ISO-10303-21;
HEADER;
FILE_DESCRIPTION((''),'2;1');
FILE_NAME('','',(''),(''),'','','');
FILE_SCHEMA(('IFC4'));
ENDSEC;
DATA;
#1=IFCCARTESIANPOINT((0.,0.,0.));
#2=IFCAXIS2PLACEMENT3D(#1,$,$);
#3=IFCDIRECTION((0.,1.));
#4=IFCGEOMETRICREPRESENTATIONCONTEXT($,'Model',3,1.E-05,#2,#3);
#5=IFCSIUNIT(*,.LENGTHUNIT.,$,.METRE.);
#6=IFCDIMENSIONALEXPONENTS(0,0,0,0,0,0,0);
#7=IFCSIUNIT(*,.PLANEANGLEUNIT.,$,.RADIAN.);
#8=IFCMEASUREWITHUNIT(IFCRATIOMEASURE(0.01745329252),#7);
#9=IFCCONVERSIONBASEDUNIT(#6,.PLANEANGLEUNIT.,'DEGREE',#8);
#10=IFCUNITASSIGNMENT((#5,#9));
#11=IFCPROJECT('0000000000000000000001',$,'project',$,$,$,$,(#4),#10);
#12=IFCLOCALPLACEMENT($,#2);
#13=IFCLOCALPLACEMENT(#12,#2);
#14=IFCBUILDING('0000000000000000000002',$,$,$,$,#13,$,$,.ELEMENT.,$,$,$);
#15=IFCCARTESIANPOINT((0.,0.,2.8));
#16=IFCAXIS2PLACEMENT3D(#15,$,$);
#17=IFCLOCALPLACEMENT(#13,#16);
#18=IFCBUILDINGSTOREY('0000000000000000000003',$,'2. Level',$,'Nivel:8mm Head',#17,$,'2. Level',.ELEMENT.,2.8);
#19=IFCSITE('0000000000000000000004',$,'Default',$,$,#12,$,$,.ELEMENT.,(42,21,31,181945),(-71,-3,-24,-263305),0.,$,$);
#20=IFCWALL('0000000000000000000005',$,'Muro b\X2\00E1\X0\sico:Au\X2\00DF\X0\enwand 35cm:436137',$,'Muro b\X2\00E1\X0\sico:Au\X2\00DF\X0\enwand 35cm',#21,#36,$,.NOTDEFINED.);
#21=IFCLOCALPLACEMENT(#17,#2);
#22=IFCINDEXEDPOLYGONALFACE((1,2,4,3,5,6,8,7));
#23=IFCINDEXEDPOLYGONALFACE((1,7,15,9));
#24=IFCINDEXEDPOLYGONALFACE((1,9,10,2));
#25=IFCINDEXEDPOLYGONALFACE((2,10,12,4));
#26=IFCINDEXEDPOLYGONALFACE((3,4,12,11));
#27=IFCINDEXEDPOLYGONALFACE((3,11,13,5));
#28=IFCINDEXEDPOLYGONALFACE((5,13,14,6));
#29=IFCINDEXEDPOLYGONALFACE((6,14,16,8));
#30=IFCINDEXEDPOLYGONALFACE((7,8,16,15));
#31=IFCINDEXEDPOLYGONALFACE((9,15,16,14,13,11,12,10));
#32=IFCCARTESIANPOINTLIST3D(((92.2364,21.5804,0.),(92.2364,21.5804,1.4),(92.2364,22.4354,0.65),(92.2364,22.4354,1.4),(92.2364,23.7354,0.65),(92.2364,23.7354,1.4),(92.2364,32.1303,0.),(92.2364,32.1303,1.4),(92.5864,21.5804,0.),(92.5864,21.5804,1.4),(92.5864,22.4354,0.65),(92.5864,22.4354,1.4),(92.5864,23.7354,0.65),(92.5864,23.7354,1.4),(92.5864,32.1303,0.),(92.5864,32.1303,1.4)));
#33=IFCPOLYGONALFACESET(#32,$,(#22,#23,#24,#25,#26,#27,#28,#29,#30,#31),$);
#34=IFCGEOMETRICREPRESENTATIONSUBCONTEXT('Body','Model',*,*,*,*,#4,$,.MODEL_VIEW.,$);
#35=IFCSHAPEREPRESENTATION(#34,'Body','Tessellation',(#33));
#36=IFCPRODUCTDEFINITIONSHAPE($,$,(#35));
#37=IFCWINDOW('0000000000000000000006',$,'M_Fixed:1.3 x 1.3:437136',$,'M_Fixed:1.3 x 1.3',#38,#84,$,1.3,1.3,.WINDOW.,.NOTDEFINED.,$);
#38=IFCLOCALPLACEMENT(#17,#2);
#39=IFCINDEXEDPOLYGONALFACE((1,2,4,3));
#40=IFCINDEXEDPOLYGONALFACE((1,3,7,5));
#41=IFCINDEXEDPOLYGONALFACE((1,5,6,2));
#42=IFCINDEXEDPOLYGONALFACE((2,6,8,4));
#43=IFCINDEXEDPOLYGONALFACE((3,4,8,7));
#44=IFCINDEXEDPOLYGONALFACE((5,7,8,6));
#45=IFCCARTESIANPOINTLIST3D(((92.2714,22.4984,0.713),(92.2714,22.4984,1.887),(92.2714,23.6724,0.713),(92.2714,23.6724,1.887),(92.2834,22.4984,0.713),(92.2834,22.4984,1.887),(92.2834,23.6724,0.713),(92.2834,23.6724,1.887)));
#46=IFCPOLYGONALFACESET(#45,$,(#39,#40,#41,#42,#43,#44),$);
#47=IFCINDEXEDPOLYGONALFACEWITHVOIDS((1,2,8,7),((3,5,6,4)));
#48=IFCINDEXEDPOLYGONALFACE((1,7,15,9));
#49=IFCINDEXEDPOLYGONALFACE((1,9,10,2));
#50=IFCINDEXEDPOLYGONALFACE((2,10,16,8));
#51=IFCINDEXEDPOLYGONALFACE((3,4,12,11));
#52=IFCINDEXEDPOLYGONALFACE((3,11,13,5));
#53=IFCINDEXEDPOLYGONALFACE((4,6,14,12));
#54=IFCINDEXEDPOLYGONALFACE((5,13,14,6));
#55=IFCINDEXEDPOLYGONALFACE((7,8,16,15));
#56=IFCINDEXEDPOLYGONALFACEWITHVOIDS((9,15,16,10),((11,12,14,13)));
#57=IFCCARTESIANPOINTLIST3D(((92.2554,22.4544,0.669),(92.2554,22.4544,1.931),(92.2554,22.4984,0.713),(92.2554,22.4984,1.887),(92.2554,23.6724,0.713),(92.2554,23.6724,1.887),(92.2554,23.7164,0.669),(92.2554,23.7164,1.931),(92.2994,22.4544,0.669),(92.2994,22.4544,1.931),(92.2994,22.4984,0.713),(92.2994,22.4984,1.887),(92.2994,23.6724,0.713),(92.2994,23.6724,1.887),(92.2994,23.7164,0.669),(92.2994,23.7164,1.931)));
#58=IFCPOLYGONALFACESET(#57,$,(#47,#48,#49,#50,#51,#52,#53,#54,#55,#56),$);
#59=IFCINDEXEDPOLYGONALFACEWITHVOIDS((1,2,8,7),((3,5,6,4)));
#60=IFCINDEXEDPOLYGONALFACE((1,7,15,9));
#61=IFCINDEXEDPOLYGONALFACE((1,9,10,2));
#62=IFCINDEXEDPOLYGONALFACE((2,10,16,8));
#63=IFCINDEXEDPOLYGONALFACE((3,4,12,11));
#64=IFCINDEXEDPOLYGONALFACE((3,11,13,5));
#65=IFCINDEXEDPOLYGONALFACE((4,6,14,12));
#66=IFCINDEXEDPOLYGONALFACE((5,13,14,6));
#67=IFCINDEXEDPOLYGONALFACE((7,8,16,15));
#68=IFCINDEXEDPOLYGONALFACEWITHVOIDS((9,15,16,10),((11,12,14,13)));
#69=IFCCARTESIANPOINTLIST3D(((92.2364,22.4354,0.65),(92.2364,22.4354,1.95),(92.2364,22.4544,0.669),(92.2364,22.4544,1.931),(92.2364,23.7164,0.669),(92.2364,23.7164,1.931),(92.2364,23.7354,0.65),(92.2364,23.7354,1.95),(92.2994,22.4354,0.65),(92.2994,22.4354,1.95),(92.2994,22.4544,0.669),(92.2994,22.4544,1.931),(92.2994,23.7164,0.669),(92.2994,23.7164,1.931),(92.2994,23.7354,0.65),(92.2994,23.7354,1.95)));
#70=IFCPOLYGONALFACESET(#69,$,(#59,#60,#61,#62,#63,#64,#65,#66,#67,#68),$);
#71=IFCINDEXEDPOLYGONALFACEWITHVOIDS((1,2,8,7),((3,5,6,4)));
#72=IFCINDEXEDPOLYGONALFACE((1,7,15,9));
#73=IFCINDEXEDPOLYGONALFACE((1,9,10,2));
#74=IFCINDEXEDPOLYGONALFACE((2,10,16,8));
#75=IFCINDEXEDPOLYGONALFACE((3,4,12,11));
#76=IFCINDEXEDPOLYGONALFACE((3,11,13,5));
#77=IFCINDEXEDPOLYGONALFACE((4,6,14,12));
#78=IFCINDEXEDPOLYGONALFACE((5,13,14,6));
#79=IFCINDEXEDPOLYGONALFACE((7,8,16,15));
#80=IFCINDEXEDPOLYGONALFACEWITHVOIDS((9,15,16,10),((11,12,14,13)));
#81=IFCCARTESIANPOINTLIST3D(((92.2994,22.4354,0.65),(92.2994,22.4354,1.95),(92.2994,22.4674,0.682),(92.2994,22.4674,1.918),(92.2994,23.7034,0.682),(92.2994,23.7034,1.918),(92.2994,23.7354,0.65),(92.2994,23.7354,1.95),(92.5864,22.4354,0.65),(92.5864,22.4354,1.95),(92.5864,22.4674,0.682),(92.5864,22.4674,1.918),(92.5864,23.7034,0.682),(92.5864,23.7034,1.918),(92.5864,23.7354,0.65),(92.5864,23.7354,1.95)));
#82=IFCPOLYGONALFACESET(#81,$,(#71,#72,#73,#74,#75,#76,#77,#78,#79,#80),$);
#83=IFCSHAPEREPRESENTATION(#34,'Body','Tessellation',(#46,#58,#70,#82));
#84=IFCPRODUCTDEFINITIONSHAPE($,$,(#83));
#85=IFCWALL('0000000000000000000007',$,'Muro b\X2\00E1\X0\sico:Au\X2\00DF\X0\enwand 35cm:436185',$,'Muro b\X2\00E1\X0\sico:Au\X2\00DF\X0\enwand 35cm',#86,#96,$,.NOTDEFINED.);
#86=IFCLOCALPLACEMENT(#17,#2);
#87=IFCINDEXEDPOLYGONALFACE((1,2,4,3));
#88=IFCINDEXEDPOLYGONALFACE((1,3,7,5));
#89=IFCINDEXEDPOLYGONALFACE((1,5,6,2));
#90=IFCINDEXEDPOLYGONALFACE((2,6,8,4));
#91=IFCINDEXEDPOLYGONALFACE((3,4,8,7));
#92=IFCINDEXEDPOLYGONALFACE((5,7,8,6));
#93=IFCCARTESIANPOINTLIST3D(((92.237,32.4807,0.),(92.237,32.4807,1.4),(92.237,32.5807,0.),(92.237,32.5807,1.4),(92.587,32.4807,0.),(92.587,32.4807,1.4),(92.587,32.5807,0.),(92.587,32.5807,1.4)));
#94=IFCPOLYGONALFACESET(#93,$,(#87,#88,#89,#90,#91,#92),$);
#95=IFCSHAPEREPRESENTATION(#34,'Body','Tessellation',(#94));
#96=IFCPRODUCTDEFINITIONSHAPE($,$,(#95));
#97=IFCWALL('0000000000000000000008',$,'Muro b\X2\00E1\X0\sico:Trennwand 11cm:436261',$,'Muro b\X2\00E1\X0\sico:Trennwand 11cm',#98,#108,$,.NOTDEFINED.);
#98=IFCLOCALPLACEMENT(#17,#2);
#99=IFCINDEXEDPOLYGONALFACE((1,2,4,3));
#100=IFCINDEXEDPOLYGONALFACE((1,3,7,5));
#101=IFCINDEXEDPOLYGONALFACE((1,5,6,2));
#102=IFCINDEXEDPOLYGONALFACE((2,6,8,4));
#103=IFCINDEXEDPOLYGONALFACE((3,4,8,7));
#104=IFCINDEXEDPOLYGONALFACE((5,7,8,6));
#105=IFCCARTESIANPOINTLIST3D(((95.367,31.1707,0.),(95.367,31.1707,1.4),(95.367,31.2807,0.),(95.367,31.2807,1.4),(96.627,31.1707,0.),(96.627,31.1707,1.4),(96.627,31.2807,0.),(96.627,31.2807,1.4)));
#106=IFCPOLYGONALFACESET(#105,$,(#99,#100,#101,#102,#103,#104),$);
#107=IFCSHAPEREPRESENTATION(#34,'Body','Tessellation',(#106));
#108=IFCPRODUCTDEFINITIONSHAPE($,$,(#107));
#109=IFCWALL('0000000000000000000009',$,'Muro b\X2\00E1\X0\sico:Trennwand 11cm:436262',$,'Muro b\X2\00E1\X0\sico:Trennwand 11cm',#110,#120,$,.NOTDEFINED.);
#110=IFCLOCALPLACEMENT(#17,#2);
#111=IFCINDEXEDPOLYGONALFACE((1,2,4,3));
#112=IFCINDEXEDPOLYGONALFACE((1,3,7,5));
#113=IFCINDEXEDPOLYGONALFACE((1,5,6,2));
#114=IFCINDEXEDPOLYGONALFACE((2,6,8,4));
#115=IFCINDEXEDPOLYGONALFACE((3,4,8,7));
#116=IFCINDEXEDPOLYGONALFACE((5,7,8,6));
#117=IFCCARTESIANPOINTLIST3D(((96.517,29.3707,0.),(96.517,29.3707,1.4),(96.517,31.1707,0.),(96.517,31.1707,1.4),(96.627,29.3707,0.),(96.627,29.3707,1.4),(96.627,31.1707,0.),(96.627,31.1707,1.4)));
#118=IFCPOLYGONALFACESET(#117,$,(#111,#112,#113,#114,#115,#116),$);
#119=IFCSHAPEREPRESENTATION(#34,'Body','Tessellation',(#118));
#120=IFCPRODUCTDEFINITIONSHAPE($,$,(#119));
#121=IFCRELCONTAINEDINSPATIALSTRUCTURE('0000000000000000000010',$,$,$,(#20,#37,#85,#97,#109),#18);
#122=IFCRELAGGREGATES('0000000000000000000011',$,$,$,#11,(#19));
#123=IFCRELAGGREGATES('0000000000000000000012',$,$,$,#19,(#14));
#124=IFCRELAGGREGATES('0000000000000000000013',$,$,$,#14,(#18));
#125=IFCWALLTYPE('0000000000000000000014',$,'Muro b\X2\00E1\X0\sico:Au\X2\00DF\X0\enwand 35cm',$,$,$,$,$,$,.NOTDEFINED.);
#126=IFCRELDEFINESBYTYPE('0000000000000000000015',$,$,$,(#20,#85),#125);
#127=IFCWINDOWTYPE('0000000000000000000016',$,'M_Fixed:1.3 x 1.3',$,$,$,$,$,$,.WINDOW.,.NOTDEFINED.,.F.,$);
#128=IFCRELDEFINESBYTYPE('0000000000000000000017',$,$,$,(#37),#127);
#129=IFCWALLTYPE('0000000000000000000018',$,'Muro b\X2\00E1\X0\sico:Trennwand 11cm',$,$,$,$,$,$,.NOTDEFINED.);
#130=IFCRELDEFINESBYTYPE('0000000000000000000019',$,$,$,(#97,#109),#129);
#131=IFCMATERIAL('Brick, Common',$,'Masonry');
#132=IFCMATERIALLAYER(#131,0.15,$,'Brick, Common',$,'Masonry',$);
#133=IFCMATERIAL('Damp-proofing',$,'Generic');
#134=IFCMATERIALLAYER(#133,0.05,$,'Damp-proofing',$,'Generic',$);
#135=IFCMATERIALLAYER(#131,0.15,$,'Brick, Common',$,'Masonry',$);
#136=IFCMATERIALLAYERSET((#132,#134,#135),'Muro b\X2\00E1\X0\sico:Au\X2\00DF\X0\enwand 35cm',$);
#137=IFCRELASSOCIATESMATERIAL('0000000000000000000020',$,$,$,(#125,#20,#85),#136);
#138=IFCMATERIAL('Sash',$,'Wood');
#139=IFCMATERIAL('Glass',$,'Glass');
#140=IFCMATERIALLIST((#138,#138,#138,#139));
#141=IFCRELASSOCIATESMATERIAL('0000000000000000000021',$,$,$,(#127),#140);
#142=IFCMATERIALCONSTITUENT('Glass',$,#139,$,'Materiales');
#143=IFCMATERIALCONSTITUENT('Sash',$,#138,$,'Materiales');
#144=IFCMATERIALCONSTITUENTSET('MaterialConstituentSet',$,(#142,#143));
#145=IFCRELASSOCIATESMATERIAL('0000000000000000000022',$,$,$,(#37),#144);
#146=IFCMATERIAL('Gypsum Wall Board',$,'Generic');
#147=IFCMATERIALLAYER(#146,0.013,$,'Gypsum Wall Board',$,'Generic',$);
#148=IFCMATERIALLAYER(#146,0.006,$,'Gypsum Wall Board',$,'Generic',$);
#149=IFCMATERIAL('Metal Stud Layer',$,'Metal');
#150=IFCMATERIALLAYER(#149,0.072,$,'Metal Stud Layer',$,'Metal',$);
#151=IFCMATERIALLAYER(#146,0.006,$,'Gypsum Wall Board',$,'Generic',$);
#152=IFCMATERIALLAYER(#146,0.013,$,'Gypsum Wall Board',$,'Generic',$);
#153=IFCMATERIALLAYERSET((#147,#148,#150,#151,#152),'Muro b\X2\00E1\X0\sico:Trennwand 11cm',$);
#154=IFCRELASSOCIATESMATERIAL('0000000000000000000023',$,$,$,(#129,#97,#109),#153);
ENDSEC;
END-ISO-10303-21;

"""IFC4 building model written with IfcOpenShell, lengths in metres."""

from ifc_helpers import new_model, entity, si_unit, converted_unit, direction, frame, frame_2d, origin, origin_2d_with_axis, place, context, subcontext, project, spatial, polyline, rectangle, outline, extrude, clip, halfspace, source, transform, mapped, material, material_list, layer, layer_set, layer_usage, constituent, constituent_set, type_object, type_shapes, element, fill, save


model = new_model("IFC4")

# Units and contexts
model_context = context("Model", 3, precision=1e-05, world=origin(), true_north=direction((0.0, 1.0)))
body_context = subcontext(model_context, "Body", "Model", "MODEL_VIEW")
ifc_project = project(units=[si_unit("LENGTHUNIT", "METRE"), converted_unit("PLANEANGLEUNIT", "DEGREE", entity("IfcRatioMeasure", 0.01745329252), si_unit("PLANEANGLEUNIT", "RADIAN"), dimensions=[0, 0, 0, 0, 0, 0, 0])], contexts=[model_context])

# Site, building, storey
site_placement = place(None, origin())
site = spatial("IfcSite", under=ifc_project, at=site_placement, Name="Default", CompositionType="ELEMENT", RefLatitude=(42, 21, 31, 181945), RefLongitude=(-71, -3, -24, -263305), RefElevation=0.0)
building_placement = place(site_placement, origin())
building = spatial("IfcBuilding", under=site, at=building_placement, CompositionType="ELEMENT")
storey_placement = place(building_placement, frame((0.0, 0.0, 2.8)))
storey = spatial("IfcBuildingStorey", under=building, at=storey_placement, Name="2. Level", ObjectType="Nivel:8mm Head", LongName="2. Level", CompositionType="ELEMENT", Elevation=2.8)

# Wall, opening, window
ifc_material_1 = material(Name="Brick, Common", Category="Masonry")
ifc_layer_1 = layer(ifc_material_1, 0.15, Name="Brick, Common", Category="Masonry")
ifc_material_2 = material(Name="Damp-proofing", Category="Generic")
ifc_layer_2 = layer(ifc_material_2, 0.05, Name="Damp-proofing", Category="Generic")
ifc_layer_3 = layer(ifc_material_1, 0.15, Name="Brick, Common", Category="Masonry")
ifc_layer_set_1 = layer_set([ifc_layer_1, ifc_layer_2, ifc_layer_3], Name="Muro básico:Außenwand 35cm")
ifc_layer_usage_1 = layer_usage(ifc_layer_set_1, "AXIS2", "NEGATIVE", 0.175)
wall_type_1 = type_object("IfcWallType", Name="Muro básico:Außenwand 35cm", PredefinedType="NOTDEFINED", material=ifc_layer_set_1)
wall_1_placement = place(storey_placement, frame((92.4114, 32.1303, 0.0), z_axis=(0.0, 0.0, 1.0), x_axis=(0.0, -1.0, 0.0)))
wall_1 = element("IfcWall", 1, at=wall_1_placement, inside=storey, type_object=wall_type_1, material=ifc_layer_usage_1, Name="Muro básico:Außenwand 35cm:436137", ObjectType="Muro básico:Außenwand 35cm", PredefinedType="NOTDEFINED", context=body_context, shape_type="Clipping", body=[
    clip(extrude(rectangle(XDim=10.55, YDim=0.35, at=frame_2d((5.275, 0.0), x_axis=(-1.0, 0.0))), origin(), (0.0, 0.0, 1.0), 1.4), halfspace(origin(), True)),
])
opening_1_placement = place(wall_1_placement, frame((9.695, 0.175, 0.65)))
opening_1 = element("IfcOpeningElement", 2, at=opening_1_placement, cuts=wall_1, ObjectType="Opening", PredefinedType="OPENING", context=body_context, shape_type="SweptSolid", body=[
    extrude(rectangle(XDim=1.3, YDim=1.3, at=frame_2d((0.65, 0.65), x_axis=(1.0, 0.0))), frame((0.0, 0.0, 0.0), z_axis=(0.0, -1.0, 0.0), x_axis=(0.0, 0.0, 1.0)), (0.0, 0.0, 1.0), 0.35),
])
ifc_material_3 = material(Name="Glass", Category="Glass")
ifc_constituent_1 = constituent(ifc_material_3, Name="Glass", Category="Materiales")
ifc_material_4 = material(Name="Sash", Category="Wood")
ifc_constituent_2 = constituent(ifc_material_4, Name="Sash", Category="Materiales")
ifc_constituent_set_1 = constituent_set(constituents=[ifc_constituent_1, ifc_constituent_2], Name="MaterialConstituentSet")
ifc_material_list_1 = material_list([ifc_material_4, ifc_material_4, ifc_material_4, ifc_material_3])
window_type = type_object("IfcWindowType", Name="M_Fixed:1.3 x 1.3", ParameterTakesPrecedence=False, PartitioningType="NOTDEFINED", PredefinedType="WINDOW", material=ifc_material_list_1)
shared_shape_1 = source(origin(), body_context, "Body", "SweptSolid", [
    extrude(rectangle(XDim=0.012, YDim=1.174, at=origin_2d_with_axis()), frame((0.65, 0.309, 0.063), z_axis=(0.0, 0.0, 1.0), x_axis=(0.0, -1.0, 0.0)), (0.0, 0.0, 1.0), 1.174),
    extrude(outline(polyline([(-0.631, -0.631), (0.631, -0.631), (0.631, 0.631), (-0.631, 0.631), (-0.631, -0.631)]), holes=[polyline([(-0.587, -0.587), (-0.587, 0.587), (0.587, 0.587), (0.587, -0.587), (-0.587, -0.587)])]), frame((0.65, 0.287, 0.65), z_axis=(0.0, 1.0, 0.0), x_axis=(1.0, 0.0, 0.0)), (0.0, 0.0, 1.0), 0.044),
    extrude(outline(polyline([(-0.65, -0.65), (0.65, -0.65), (0.65, 0.65), (-0.65, 0.65), (-0.65, -0.65)]), holes=[polyline([(-0.631, -0.631), (-0.631, 0.631), (0.631, 0.631), (0.631, -0.631), (-0.631, -0.631)])]), frame((0.65, 0.287, 0.65), z_axis=(0.0, 1.0, 0.0), x_axis=(1.0, 0.0, 0.0)), (0.0, 0.0, 1.0), 0.063),
    extrude(outline(polyline([(-0.65, -0.65), (0.65, -0.65), (0.65, 0.65), (-0.65, 0.65), (-0.65, -0.65)]), holes=[polyline([(-0.618, -0.618), (-0.618, 0.618), (0.618, 0.618), (0.618, -0.618), (-0.618, -0.618)])]), frame((0.65, 0.0, 0.65), z_axis=(0.0, 1.0, 0.0), x_axis=(1.0, 0.0, 0.0)), (0.0, 0.0, 1.0), 0.287),
])
type_shapes(window_type, [shared_shape_1])
window_placement = place(opening_1_placement, frame((0.0, 0.0, 0.0), z_axis=(0.0, 0.0, 1.0), x_axis=(-1.0, 0.0, 0.0)))
window = element("IfcWindow", 3, at=window_placement, inside=storey, type_object=window_type, material=ifc_constituent_set_1, Name="M_Fixed:1.3 x 1.3:437136", ObjectType="M_Fixed:1.3 x 1.3", OverallHeight=1.3, OverallWidth=1.3, PartitioningType="NOTDEFINED", PredefinedType="WINDOW", context=body_context, shape_type="MappedRepresentation", body=[
    mapped(shared_shape_1, transform((0.0, 0.0, 0.0), scale=1.0)),
])
fill(opening_1, window)

# Walls
ifc_layer_usage_2 = layer_usage(ifc_layer_set_1, "AXIS2", "NEGATIVE", 0.175)
wall_2_placement = place(storey_placement, frame((92.412, 32.5807, 0.0), z_axis=(0.0, 0.0, 1.0), x_axis=(0.0, -1.0, 0.0)))
element("IfcWall", 4, at=wall_2_placement, inside=storey, type_object=wall_type_1, material=ifc_layer_usage_2, Name="Muro básico:Außenwand 35cm:436185", ObjectType="Muro básico:Außenwand 35cm", PredefinedType="NOTDEFINED", context=body_context, shape_type="Clipping", body=[
    clip(extrude(rectangle(XDim=0.1, YDim=0.35, at=frame_2d((0.05, 0.0), x_axis=(-1.0, 0.0))), origin(), (0.0, 0.0, 1.0), 1.4), halfspace(origin(), True)),
])
ifc_material_5 = material(Name="Gypsum Wall Board", Category="Generic")
ifc_layer_4 = layer(ifc_material_5, 0.013, Name="Gypsum Wall Board", Category="Generic")
ifc_layer_5 = layer(ifc_material_5, 0.006, Name="Gypsum Wall Board", Category="Generic")
ifc_material_6 = material(Name="Metal Stud Layer", Category="Metal")
ifc_layer_6 = layer(ifc_material_6, 0.072, Name="Metal Stud Layer", Category="Metal")
ifc_layer_7 = layer(ifc_material_5, 0.006, Name="Gypsum Wall Board", Category="Generic")
ifc_layer_8 = layer(ifc_material_5, 0.013, Name="Gypsum Wall Board", Category="Generic")
ifc_layer_set_2 = layer_set([ifc_layer_4, ifc_layer_5, ifc_layer_6, ifc_layer_7, ifc_layer_8], Name="Muro básico:Trennwand 11cm")
ifc_layer_usage_3 = layer_usage(ifc_layer_set_2, "AXIS2", "NEGATIVE", 0.055)
wall_type_2 = type_object("IfcWallType", Name="Muro básico:Trennwand 11cm", PredefinedType="NOTDEFINED", material=ifc_layer_set_2)
wall_3_placement = place(storey_placement, frame((95.367, 31.2257, 0.0)))
element("IfcWall", 5, at=wall_3_placement, inside=storey, type_object=wall_type_2, material=ifc_layer_usage_3, Name="Muro básico:Trennwand 11cm:436261", ObjectType="Muro básico:Trennwand 11cm", PredefinedType="NOTDEFINED", context=body_context, shape_type="Clipping", body=[
    clip(extrude(rectangle(XDim=1.26, YDim=0.11, at=frame_2d((0.63, 0.0), x_axis=(-1.0, 0.0))), origin(), (0.0, 0.0, 1.0), 1.4), halfspace(origin(), True)),
])
ifc_layer_usage_4 = layer_usage(ifc_layer_set_2, "AXIS2", "NEGATIVE", 0.055)
wall_4_placement = place(storey_placement, frame((96.572, 31.1707, 0.0), z_axis=(0.0, 0.0, 1.0), x_axis=(0.0, -1.0, 0.0)))
element("IfcWall", 6, at=wall_4_placement, inside=storey, type_object=wall_type_2, material=ifc_layer_usage_4, Name="Muro básico:Trennwand 11cm:436262", ObjectType="Muro básico:Trennwand 11cm", PredefinedType="NOTDEFINED", context=body_context, shape_type="Clipping", body=[
    clip(extrude(rectangle(XDim=1.8, YDim=0.11, at=frame_2d((0.9, 0.0), x_axis=(-1.0, 0.0))), origin(), (0.0, 0.0, 1.0), 1.4), halfspace(origin(), True)),
])

save(model, "model.ifc")
